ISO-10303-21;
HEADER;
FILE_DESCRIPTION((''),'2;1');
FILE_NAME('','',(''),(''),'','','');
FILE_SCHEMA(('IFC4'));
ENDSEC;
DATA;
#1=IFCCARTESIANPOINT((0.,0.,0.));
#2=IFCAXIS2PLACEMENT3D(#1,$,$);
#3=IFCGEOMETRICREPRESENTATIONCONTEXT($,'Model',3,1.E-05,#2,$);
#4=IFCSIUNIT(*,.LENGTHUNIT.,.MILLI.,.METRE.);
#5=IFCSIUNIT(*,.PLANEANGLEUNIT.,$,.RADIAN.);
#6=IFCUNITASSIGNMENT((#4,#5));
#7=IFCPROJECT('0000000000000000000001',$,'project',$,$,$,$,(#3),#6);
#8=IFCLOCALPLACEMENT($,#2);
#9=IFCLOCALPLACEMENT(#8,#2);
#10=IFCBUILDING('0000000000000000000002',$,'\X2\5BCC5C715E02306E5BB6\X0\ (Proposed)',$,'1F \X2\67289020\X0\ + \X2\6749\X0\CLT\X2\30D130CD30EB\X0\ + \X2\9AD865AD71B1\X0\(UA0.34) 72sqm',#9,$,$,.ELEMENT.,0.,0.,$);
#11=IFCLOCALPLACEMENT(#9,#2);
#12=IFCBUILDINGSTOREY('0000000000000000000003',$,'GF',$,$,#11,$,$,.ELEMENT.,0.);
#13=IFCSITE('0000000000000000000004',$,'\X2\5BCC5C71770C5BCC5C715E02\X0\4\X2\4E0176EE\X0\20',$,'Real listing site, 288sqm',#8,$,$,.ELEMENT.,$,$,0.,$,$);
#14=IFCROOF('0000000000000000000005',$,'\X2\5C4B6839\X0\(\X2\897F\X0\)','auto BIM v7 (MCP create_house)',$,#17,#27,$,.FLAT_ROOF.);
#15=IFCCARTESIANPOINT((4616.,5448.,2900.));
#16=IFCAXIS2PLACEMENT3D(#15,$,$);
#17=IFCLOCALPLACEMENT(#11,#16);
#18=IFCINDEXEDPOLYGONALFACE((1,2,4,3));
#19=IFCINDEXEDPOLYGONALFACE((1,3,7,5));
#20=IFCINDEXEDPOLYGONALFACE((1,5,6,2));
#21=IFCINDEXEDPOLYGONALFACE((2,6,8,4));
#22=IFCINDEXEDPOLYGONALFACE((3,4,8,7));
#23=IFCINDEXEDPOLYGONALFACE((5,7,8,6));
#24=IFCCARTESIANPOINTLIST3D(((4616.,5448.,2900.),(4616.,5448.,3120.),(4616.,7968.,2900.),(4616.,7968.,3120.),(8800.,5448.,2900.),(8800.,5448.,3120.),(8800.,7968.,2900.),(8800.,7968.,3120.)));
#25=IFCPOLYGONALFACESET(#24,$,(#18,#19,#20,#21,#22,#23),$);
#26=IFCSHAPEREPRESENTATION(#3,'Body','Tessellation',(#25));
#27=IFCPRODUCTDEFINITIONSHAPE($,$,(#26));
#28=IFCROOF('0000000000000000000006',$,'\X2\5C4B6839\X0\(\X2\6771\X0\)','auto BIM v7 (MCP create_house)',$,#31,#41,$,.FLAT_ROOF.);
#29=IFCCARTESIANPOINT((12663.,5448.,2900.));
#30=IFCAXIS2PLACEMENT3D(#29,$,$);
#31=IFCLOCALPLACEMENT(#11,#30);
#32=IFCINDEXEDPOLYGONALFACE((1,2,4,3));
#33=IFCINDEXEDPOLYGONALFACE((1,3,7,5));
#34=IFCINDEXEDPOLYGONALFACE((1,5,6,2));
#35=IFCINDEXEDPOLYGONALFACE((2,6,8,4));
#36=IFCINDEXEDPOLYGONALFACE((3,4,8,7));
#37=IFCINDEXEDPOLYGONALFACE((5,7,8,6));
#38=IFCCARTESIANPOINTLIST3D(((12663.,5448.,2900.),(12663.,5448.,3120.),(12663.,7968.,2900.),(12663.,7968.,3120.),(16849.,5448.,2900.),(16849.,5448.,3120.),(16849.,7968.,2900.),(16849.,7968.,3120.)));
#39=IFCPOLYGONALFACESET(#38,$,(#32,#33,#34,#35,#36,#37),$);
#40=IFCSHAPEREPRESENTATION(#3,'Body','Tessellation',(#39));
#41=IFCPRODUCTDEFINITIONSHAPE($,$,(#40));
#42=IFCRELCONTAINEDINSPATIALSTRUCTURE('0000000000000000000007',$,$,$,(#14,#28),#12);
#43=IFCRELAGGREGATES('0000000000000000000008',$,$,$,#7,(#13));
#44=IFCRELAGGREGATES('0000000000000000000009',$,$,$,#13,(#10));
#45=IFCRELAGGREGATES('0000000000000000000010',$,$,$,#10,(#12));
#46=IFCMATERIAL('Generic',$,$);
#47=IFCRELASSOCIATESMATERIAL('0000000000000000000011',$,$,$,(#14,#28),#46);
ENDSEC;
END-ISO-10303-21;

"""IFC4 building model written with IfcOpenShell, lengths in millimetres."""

from ifc_helpers import new_model, si_unit, frame, frame_2d, origin, place, context, project, spatial, rectangle, extrude, material, element, save


model = new_model("IFC4")

# Units and contexts
model_context = context("Model", 3, precision=1e-05, world=origin())
ifc_project = project(units=[si_unit("LENGTHUNIT", "METRE", prefix="MILLI"), si_unit("PLANEANGLEUNIT", "RADIAN")], contexts=[model_context])

# Site, building, storey
site_placement = place(None, origin())
site = spatial("IfcSite", under=ifc_project, at=site_placement, Name="富山県富山市4丁目20", ObjectType="Real listing site, 288sqm", CompositionType="ELEMENT", RefElevation=0.0)
building_placement = place(site_placement, origin())
building = spatial("IfcBuilding", under=site, at=building_placement, Name="富山市の家 (Proposed)", ObjectType="1F 木造 + 杉CLTパネル + 高断熱(UA0.34) 72sqm", CompositionType="ELEMENT", ElevationOfRefHeight=0.0, ElevationOfTerrain=0.0)
storey_placement = place(building_placement, origin())
storey = spatial("IfcBuildingStorey", under=building, at=storey_placement, Name="GF", CompositionType="ELEMENT", Elevation=0.0)

# Shared definitions
ifc_material = material(Name="Generic")

# Roofs
roof_1_placement = place(storey_placement, frame((4616.0, 5448.0, 2900.0)))
element("IfcRoof", 1, at=roof_1_placement, inside=storey, material=ifc_material, Name="屋根(西)", Description="auto BIM v7 (MCP create_house)", PredefinedType="FLAT_ROOF", context=model_context, shape_type="SweptSolid", body=[
    extrude(rectangle(XDim=4184.0, YDim=2520.0, at=frame_2d((2092.0, 1260.0))), frame((4616.0, 5448.0, 2900.0)), (0.0, 0.0, 1.0), 220.0),
])
roof_2_placement = place(storey_placement, frame((12663.0, 5448.0, 2900.0)))
element("IfcRoof", 2, at=roof_2_placement, inside=storey, material=ifc_material, Name="屋根(東)", Description="auto BIM v7 (MCP create_house)", PredefinedType="FLAT_ROOF", context=model_context, shape_type="SweptSolid", body=[
    extrude(rectangle(XDim=4186.0, YDim=2520.0, at=frame_2d((2093.0, 1260.0))), frame((12663.0, 5448.0, 2900.0)), (0.0, 0.0, 1.0), 220.0),
])

save(model, "model.ifc")
